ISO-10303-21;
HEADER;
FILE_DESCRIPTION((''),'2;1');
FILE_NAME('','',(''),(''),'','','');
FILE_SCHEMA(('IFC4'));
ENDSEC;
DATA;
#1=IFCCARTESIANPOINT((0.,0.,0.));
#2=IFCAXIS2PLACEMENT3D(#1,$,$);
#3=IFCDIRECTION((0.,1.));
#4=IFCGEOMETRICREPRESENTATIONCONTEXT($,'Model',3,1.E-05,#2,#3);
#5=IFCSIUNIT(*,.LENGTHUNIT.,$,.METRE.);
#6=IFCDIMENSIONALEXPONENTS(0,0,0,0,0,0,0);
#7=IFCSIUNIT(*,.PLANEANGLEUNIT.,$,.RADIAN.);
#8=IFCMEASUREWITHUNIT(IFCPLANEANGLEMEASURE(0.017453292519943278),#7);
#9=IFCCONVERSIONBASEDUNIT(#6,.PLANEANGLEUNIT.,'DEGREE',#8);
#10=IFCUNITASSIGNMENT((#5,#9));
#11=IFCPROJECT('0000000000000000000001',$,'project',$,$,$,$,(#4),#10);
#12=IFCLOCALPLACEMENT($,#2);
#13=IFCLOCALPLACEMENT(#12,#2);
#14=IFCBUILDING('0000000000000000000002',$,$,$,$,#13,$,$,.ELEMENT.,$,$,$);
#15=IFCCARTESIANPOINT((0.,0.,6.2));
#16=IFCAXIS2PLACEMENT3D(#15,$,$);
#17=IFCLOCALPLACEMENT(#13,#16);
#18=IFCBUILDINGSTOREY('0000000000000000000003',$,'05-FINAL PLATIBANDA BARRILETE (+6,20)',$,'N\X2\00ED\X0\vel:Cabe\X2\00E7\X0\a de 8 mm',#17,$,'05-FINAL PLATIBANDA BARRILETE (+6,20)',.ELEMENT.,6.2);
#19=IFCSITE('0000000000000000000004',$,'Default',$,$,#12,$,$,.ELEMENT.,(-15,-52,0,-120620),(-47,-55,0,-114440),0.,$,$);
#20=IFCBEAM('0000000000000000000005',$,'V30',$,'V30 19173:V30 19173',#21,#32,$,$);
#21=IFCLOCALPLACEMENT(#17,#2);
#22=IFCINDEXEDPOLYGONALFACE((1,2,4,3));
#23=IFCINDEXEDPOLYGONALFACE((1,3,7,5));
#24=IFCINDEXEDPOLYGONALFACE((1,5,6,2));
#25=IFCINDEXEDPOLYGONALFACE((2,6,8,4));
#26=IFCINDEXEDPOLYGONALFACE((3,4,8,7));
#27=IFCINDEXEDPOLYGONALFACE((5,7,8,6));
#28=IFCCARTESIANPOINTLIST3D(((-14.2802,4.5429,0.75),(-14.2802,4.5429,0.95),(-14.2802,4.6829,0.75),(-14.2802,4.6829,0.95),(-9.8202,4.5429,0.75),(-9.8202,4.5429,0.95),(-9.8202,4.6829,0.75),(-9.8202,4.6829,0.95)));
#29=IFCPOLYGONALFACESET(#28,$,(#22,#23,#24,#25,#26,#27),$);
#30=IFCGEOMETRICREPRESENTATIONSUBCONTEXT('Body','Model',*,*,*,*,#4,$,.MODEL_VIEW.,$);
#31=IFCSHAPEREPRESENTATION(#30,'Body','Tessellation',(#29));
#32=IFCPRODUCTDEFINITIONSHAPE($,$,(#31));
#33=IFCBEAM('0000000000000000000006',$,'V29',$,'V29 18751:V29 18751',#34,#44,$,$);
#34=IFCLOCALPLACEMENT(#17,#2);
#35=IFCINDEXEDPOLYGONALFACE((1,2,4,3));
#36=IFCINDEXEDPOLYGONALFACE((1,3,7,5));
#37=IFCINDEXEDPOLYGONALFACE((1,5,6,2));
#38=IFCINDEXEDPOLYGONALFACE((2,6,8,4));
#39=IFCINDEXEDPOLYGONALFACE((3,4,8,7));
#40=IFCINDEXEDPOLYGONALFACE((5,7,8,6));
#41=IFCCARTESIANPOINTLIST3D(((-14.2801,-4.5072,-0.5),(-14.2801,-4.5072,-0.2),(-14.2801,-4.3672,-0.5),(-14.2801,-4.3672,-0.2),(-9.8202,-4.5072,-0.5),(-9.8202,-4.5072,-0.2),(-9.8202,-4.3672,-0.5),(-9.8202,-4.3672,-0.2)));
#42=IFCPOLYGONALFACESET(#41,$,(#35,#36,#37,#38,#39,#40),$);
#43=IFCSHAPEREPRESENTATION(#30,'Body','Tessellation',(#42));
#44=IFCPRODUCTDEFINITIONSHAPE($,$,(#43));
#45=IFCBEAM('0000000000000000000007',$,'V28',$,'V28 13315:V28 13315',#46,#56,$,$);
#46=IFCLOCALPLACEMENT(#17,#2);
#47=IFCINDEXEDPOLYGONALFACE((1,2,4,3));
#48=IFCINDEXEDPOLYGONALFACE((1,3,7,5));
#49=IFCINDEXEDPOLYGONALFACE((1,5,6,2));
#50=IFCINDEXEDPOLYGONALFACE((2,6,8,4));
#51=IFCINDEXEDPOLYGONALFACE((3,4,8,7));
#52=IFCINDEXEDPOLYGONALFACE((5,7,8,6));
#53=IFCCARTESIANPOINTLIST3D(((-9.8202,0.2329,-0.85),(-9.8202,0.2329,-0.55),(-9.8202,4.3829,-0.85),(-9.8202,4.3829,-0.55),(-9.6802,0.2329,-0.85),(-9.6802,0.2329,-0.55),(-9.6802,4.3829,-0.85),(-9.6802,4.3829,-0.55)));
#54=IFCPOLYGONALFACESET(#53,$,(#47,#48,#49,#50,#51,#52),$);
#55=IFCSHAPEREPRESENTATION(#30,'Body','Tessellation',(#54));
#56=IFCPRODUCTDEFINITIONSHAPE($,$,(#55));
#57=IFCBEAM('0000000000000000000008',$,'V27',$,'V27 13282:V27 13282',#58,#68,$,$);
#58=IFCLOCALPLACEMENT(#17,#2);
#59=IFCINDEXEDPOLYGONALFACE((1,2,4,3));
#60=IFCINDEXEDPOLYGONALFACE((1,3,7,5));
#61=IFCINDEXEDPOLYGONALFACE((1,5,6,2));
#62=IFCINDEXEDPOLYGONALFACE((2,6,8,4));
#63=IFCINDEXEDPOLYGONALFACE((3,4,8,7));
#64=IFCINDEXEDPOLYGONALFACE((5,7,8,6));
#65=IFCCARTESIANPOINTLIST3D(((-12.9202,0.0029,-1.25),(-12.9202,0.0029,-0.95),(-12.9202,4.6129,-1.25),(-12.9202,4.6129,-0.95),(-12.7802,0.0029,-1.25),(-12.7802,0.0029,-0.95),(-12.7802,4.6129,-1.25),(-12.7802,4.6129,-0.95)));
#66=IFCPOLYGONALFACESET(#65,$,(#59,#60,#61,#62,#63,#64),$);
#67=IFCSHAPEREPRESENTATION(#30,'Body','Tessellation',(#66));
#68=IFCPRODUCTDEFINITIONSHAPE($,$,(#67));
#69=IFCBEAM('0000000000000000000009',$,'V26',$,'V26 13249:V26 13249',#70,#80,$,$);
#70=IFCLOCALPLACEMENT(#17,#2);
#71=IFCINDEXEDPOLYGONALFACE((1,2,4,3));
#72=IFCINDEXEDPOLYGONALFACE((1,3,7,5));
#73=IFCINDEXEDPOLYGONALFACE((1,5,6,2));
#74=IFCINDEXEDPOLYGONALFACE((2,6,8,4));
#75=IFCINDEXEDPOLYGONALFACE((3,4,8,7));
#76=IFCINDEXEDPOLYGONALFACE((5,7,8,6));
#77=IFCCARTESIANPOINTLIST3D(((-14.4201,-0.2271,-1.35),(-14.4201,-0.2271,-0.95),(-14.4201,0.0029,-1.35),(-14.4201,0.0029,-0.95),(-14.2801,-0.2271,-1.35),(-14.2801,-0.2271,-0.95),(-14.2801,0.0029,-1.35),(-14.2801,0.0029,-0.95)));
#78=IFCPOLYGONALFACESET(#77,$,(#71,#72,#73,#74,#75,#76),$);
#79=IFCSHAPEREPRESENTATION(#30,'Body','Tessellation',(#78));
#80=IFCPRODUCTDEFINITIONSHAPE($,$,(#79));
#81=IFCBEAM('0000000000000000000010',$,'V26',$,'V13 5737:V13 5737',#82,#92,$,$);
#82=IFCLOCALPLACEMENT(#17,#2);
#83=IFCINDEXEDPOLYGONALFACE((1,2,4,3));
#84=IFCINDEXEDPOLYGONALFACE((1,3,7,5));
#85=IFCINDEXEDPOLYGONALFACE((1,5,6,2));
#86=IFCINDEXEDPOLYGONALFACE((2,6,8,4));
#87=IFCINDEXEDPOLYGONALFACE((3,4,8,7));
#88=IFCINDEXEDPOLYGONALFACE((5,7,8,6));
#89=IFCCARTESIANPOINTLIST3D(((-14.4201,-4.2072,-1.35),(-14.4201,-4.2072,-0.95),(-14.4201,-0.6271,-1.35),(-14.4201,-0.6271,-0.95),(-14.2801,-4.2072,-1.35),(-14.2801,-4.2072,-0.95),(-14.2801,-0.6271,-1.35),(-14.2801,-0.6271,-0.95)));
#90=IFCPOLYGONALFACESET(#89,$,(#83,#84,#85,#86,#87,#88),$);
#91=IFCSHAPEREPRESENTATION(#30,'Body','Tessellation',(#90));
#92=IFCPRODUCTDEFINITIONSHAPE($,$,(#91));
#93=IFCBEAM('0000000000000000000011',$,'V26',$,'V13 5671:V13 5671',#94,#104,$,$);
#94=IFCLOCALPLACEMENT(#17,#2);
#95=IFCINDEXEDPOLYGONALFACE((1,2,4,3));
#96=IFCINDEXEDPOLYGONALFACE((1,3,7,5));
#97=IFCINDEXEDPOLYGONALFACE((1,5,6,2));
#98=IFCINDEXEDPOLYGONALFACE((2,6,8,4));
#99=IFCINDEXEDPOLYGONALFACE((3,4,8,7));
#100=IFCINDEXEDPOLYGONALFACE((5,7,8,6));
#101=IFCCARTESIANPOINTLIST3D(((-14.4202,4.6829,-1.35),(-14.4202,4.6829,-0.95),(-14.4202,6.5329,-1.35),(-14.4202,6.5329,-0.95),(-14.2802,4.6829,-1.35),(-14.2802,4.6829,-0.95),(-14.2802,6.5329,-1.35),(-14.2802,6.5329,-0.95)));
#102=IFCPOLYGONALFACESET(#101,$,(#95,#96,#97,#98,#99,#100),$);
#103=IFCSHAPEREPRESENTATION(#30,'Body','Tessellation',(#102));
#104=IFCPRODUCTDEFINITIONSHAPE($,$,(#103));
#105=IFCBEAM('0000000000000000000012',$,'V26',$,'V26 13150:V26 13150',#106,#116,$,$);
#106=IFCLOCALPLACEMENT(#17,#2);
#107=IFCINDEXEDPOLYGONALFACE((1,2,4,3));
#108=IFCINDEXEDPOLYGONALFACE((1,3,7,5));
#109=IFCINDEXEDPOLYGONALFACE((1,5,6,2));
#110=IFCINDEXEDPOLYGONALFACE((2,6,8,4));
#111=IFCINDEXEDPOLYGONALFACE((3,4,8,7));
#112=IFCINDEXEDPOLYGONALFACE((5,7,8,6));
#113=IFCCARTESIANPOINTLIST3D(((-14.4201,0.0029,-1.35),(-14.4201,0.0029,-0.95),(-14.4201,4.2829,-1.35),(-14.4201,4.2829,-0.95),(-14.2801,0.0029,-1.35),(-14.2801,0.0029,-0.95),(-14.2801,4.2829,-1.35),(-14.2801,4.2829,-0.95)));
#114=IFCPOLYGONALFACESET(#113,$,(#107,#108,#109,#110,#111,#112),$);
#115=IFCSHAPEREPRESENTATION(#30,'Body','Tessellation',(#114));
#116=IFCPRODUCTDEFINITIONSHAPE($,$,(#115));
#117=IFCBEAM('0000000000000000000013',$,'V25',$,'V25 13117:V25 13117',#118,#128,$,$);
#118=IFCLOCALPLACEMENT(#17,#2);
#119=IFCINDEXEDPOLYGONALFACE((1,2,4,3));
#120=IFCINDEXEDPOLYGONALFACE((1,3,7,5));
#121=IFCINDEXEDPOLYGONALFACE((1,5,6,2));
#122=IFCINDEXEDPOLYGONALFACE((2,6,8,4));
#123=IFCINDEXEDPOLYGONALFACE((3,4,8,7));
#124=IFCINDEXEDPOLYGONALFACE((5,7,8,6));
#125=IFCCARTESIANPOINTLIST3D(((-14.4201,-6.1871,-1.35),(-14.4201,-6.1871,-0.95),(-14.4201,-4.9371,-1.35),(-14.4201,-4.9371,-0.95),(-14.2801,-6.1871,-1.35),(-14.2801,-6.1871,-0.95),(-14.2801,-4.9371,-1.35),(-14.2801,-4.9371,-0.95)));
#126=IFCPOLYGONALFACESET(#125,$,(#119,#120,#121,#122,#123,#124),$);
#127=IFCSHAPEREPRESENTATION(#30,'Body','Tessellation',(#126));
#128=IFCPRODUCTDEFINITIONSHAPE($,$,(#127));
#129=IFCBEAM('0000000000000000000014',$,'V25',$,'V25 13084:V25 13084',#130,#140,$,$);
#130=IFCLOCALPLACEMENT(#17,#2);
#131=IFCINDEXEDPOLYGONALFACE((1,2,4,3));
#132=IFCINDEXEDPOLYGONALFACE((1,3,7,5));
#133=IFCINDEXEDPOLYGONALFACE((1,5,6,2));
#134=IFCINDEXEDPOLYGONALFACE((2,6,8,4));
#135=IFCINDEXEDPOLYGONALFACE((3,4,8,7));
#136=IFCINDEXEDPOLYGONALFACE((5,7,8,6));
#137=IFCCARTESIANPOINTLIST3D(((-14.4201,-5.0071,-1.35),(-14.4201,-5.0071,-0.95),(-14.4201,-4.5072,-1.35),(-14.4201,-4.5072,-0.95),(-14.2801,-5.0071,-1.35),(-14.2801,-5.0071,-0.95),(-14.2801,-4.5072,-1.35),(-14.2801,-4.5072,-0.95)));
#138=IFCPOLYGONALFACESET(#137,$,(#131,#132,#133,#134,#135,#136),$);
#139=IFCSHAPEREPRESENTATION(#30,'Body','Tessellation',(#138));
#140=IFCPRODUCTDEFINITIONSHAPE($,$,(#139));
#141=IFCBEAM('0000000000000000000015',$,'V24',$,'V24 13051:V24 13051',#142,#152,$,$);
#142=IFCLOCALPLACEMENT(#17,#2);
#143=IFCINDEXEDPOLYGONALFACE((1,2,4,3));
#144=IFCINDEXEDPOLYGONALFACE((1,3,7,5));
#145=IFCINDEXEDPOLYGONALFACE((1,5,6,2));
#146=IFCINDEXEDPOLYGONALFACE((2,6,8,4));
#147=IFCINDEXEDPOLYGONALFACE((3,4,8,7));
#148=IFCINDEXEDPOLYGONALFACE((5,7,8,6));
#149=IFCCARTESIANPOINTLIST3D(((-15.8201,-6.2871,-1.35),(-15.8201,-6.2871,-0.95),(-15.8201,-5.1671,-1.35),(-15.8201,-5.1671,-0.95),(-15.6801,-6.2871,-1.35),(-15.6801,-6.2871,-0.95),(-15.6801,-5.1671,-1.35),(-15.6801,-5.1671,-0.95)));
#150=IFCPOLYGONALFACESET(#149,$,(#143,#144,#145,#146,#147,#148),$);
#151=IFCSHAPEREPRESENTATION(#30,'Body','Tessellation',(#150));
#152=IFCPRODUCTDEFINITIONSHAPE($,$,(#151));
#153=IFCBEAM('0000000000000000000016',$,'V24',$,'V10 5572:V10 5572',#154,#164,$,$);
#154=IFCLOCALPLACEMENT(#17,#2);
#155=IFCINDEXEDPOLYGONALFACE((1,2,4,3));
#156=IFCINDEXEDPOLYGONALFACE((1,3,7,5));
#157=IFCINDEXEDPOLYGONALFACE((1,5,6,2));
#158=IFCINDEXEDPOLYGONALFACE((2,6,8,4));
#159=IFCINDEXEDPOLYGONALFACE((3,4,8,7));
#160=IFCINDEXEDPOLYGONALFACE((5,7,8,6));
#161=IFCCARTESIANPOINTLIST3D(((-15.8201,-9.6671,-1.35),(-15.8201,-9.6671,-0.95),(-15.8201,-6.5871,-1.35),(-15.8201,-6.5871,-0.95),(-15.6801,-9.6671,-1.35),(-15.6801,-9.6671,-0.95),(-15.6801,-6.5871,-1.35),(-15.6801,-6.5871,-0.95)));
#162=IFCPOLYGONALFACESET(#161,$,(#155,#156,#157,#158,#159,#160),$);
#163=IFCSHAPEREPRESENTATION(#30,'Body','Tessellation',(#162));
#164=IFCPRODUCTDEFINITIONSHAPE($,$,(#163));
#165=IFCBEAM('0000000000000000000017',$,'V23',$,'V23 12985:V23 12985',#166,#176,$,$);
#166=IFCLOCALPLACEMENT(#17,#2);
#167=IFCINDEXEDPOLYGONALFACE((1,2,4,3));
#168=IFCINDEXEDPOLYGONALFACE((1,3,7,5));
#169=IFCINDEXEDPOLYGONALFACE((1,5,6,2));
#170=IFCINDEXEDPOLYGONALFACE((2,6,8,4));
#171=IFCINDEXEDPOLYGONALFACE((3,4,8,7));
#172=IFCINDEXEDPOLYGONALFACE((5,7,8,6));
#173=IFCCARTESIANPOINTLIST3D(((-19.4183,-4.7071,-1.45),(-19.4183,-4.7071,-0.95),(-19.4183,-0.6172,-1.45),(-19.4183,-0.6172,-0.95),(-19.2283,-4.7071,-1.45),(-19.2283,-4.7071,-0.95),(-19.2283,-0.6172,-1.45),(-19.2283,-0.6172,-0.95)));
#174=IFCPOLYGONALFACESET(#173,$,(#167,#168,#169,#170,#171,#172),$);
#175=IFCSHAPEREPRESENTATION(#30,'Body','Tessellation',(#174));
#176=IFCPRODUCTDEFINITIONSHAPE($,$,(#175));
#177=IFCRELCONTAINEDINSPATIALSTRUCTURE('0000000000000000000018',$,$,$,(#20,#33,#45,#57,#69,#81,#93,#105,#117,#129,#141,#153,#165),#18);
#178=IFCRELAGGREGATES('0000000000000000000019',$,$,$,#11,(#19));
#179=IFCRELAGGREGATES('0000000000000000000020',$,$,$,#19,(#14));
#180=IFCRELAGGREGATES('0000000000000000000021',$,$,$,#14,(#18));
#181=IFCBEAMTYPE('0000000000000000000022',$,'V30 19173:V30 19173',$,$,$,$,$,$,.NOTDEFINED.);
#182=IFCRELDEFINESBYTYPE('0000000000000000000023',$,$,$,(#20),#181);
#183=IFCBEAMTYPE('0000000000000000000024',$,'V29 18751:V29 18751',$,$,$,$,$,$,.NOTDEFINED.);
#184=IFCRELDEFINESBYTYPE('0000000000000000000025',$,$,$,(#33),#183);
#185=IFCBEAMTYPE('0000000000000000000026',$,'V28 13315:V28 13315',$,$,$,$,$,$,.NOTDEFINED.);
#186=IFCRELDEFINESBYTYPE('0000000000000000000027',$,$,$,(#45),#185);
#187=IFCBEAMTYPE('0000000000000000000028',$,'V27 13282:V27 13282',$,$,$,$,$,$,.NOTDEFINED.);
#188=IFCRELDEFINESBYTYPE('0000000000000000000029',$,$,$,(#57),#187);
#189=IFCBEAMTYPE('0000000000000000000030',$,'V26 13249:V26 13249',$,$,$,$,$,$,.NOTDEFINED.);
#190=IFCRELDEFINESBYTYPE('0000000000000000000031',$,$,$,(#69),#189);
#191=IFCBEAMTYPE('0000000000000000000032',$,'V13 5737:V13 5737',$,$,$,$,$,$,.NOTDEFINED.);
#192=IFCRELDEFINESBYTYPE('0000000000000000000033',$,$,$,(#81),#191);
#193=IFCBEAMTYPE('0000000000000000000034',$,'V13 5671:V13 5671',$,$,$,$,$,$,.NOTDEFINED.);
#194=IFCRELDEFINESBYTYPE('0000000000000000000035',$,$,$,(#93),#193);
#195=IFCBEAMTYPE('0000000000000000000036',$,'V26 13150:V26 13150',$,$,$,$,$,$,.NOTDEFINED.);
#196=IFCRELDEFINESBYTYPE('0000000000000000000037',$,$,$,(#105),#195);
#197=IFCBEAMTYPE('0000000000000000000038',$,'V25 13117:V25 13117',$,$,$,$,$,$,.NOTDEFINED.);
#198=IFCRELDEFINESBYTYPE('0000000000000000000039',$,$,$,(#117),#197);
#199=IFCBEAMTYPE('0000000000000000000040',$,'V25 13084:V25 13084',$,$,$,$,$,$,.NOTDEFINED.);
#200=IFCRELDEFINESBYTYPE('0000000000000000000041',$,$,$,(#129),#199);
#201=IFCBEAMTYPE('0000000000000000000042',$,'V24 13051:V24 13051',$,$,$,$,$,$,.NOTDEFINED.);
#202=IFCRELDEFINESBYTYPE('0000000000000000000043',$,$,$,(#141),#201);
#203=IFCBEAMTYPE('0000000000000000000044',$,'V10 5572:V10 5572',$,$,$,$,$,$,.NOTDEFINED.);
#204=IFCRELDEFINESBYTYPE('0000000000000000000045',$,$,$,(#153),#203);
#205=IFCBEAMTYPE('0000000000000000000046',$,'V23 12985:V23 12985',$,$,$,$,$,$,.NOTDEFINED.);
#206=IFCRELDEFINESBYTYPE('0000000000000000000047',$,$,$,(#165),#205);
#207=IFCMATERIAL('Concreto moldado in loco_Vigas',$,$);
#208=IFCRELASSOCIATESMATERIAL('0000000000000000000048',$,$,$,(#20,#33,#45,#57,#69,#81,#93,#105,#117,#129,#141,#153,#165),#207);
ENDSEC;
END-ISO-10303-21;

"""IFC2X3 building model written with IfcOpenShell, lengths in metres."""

from ifc_helpers import new_model, entity, si_unit, converted_unit, direction, frame, frame_2d, origin, place, context, subcontext, project, spatial, rectangle, extrude, material, type_object, element, save


model = new_model("IFC2X3")

# Units and contexts
model_context = context("Model", 3, precision=1e-05, world=origin(), true_north=direction((0.0, 1.0)))
body_context = subcontext(model_context, "Body", "Model", "MODEL_VIEW")
ifc_project = project(units=[si_unit("LENGTHUNIT", "METRE"), converted_unit("PLANEANGLEUNIT", "DEGREE", entity("IfcPlaneAngleMeasure", 0.017453292519943278), si_unit("PLANEANGLEUNIT", "RADIAN"), dimensions=[0, 0, 0, 0, 0, 0, 0])], contexts=[model_context])

# Site, building, storey
site_placement = place(None, origin())
site = spatial("IfcSite", under=ifc_project, at=site_placement, Name="Default", CompositionType="ELEMENT", RefLatitude=(-15, -52, 0, -120620), RefLongitude=(-47, -55, 0, -114440), RefElevation=0.0)
building_placement = place(site_placement, origin())
building = spatial("IfcBuilding", under=site, at=building_placement, CompositionType="ELEMENT")
storey_placement = place(building_placement, frame((0.0, 0.0, 6.2)))
storey = spatial("IfcBuildingStorey", under=building, at=storey_placement, Name="05-FINAL PLATIBANDA BARRILETE (+6,20)", ObjectType="Nível:Cabeça de 8 mm", LongName="05-FINAL PLATIBANDA BARRILETE (+6,20)", CompositionType="ELEMENT", Elevation=6.2)

# Beams
ifc_material_1 = material(Name="Concreto moldado in loco_Vigas")
beam_type_1 = type_object("IfcBeamType", Name="V30 19173:V30 19173", PredefinedType="NOTDEFINED")
beam_1_placement = place(storey_placement, origin())
element("IfcBeam", 1, at=beam_1_placement, inside=storey, type_object=beam_type_1, material=ifc_material_1, Name="V30", ObjectType="V30 19173:V30 19173", context=body_context, shape_type="SweptSolid", body=[
    extrude(rectangle(XDim=0.2, YDim=0.14, at=frame_2d((0.0, 0.0), x_axis=(1.0, 0.0))), frame((-14.2802, 4.6129, 0.85), z_axis=(1.0, 0.0, 0.0), x_axis=(0.0, 0.0, -1.0)), (0.0, 0.0, 1.0), 4.46),
])
beam_type_2 = type_object("IfcBeamType", Name="V29 18751:V29 18751", PredefinedType="NOTDEFINED")
beam_2_placement = place(storey_placement, origin())
element("IfcBeam", 2, at=beam_2_placement, inside=storey, type_object=beam_type_2, material=ifc_material_1, Name="V29", ObjectType="V29 18751:V29 18751", context=body_context, shape_type="SweptSolid", body=[
    extrude(rectangle(XDim=0.3, YDim=0.14, at=frame_2d((0.0, 0.0), x_axis=(1.0, 0.0))), frame((-14.2801, -4.4372, -0.35), z_axis=(1.0, 0.0, 0.0), x_axis=(0.0, 0.0, -1.0)), (0.0, 0.0, 1.0), 4.4599),
])
beam_type_3 = type_object("IfcBeamType", Name="V28 13315:V28 13315", PredefinedType="NOTDEFINED")
beam_3_placement = place(storey_placement, origin())
element("IfcBeam", 3, at=beam_3_placement, inside=storey, type_object=beam_type_3, material=ifc_material_1, Name="V28", ObjectType="V28 13315:V28 13315", context=body_context, shape_type="SweptSolid", body=[
    extrude(rectangle(XDim=0.3, YDim=4.15, at=frame_2d((0.0, 0.0), x_axis=(0.0, 1.0))), frame((-9.8202, 2.3079, -0.7), z_axis=(1.0, 0.0, 0.0), x_axis=(0.0, -1.0, 0.0)), (0.0, 0.0, 1.0), 0.14),
])
beam_type_4 = type_object("IfcBeamType", Name="V27 13282:V27 13282", PredefinedType="NOTDEFINED")
beam_4_placement = place(storey_placement, origin())
element("IfcBeam", 4, at=beam_4_placement, inside=storey, type_object=beam_type_4, material=ifc_material_1, Name="V27", ObjectType="V27 13282:V27 13282", context=body_context, shape_type="SweptSolid", body=[
    extrude(rectangle(XDim=0.3, YDim=4.61, at=frame_2d((0.0, 0.0), x_axis=(0.0, 1.0))), frame((-12.9202, 2.3079, -1.1), z_axis=(1.0, 0.0, 0.0), x_axis=(0.0, -1.0, 0.0)), (0.0, 0.0, 1.0), 0.14),
])
beam_type_5 = type_object("IfcBeamType", Name="V26 13249:V26 13249", PredefinedType="NOTDEFINED")
beam_5_placement = place(storey_placement, origin())
element("IfcBeam", 5, at=beam_5_placement, inside=storey, type_object=beam_type_5, material=ifc_material_1, Name="V26", ObjectType="V26 13249:V26 13249", context=body_context, shape_type="SweptSolid", body=[
    extrude(rectangle(XDim=0.4, YDim=0.23, at=frame_2d((0.0, 0.0), x_axis=(0.0, 1.0))), frame((-14.4201, -0.1121, -1.15), z_axis=(1.0, 0.0, 0.0), x_axis=(0.0, -1.0, 0.0)), (0.0, 0.0, 1.0), 0.14),
])
beam_type_6 = type_object("IfcBeamType", Name="V13 5737:V13 5737", PredefinedType="NOTDEFINED")
beam_6_placement = place(storey_placement, origin())
element("IfcBeam", 6, at=beam_6_placement, inside=storey, type_object=beam_type_6, material=ifc_material_1, Name="V26", ObjectType="V13 5737:V13 5737", context=body_context, shape_type="SweptSolid", body=[
    extrude(rectangle(XDim=0.4, YDim=3.5801, at=frame_2d((0.0, 0.0), x_axis=(0.0, 1.0))), frame((-14.4201, -2.4171, -1.15), z_axis=(1.0, 0.0, 0.0), x_axis=(0.0, -1.0, 0.0)), (0.0, 0.0, 1.0), 0.14),
])
beam_type_7 = type_object("IfcBeamType", Name="V13 5671:V13 5671", PredefinedType="NOTDEFINED")
beam_7_placement = place(storey_placement, origin())
element("IfcBeam", 7, at=beam_7_placement, inside=storey, type_object=beam_type_7, material=ifc_material_1, Name="V26", ObjectType="V13 5671:V13 5671", context=body_context, shape_type="SweptSolid", body=[
    extrude(rectangle(XDim=0.4, YDim=1.85, at=frame_2d((0.0, 0.0), x_axis=(0.0, 1.0))), frame((-14.4202, 5.6079, -1.15), z_axis=(1.0, 0.0, 0.0), x_axis=(0.0, -1.0, 0.0)), (0.0, 0.0, 1.0), 0.14),
])
beam_type_8 = type_object("IfcBeamType", Name="V26 13150:V26 13150", PredefinedType="NOTDEFINED")
beam_8_placement = place(storey_placement, origin())
element("IfcBeam", 8, at=beam_8_placement, inside=storey, type_object=beam_type_8, material=ifc_material_1, Name="V26", ObjectType="V26 13150:V26 13150", context=body_context, shape_type="SweptSolid", body=[
    extrude(rectangle(XDim=0.4, YDim=4.28, at=frame_2d((0.0, 0.0), x_axis=(0.0, 1.0))), frame((-14.4201, 2.1429, -1.15), z_axis=(1.0, 0.0, 0.0), x_axis=(0.0, -1.0, 0.0)), (0.0, 0.0, 1.0), 0.14),
])
beam_type_9 = type_object("IfcBeamType", Name="V25 13117:V25 13117", PredefinedType="NOTDEFINED")
beam_9_placement = place(storey_placement, origin())
element("IfcBeam", 9, at=beam_9_placement, inside=storey, type_object=beam_type_9, material=ifc_material_1, Name="V25", ObjectType="V25 13117:V25 13117", context=body_context, shape_type="SweptSolid", body=[
    extrude(rectangle(XDim=0.4, YDim=1.25, at=frame_2d((0.0, 0.0), x_axis=(0.0, 1.0))), frame((-14.4201, -5.5621, -1.15), z_axis=(1.0, 0.0, 0.0), x_axis=(0.0, -1.0, 0.0)), (0.0, 0.0, 1.0), 0.14),
])
beam_type_10 = type_object("IfcBeamType", Name="V25 13084:V25 13084", PredefinedType="NOTDEFINED")
beam_10_placement = place(storey_placement, origin())
element("IfcBeam", 10, at=beam_10_placement, inside=storey, type_object=beam_type_10, material=ifc_material_1, Name="V25", ObjectType="V25 13084:V25 13084", context=body_context, shape_type="SweptSolid", body=[
    extrude(rectangle(XDim=0.4, YDim=0.4999, at=frame_2d((0.0, 0.0), x_axis=(0.0, 1.0))), frame((-14.4201, -4.7571, -1.15), z_axis=(1.0, 0.0, 0.0), x_axis=(0.0, -1.0, 0.0)), (0.0, 0.0, 1.0), 0.14),
])
beam_type_11 = type_object("IfcBeamType", Name="V24 13051:V24 13051", PredefinedType="NOTDEFINED")
beam_11_placement = place(storey_placement, origin())
element("IfcBeam", 11, at=beam_11_placement, inside=storey, type_object=beam_type_11, material=ifc_material_1, Name="V24", ObjectType="V24 13051:V24 13051", context=body_context, shape_type="SweptSolid", body=[
    extrude(rectangle(XDim=0.4, YDim=1.12, at=frame_2d((0.0, 0.0), x_axis=(0.0, 1.0))), frame((-15.8201, -5.7271, -1.15), z_axis=(1.0, 0.0, 0.0), x_axis=(0.0, -1.0, 0.0)), (0.0, 0.0, 1.0), 0.14),
])
beam_type_12 = type_object("IfcBeamType", Name="V10 5572:V10 5572", PredefinedType="NOTDEFINED")
beam_12_placement = place(storey_placement, origin())
element("IfcBeam", 12, at=beam_12_placement, inside=storey, type_object=beam_type_12, material=ifc_material_1, Name="V24", ObjectType="V10 5572:V10 5572", context=body_context, shape_type="SweptSolid", body=[
    extrude(rectangle(XDim=0.4, YDim=3.08, at=frame_2d((0.0, 0.0), x_axis=(0.0, 1.0))), frame((-15.8201, -8.1271, -1.15), z_axis=(1.0, 0.0, 0.0), x_axis=(0.0, -1.0, 0.0)), (0.0, 0.0, 1.0), 0.14),
])
beam_type_13 = type_object("IfcBeamType", Name="V23 12985:V23 12985", PredefinedType="NOTDEFINED")
beam_13_placement = place(storey_placement, origin())
element("IfcBeam", 13, at=beam_13_placement, inside=storey, type_object=beam_type_13, material=ifc_material_1, Name="V23", ObjectType="V23 12985:V23 12985", context=body_context, shape_type="SweptSolid", body=[
    extrude(rectangle(XDim=0.5, YDim=4.0899, at=frame_2d((0.0, 0.0), x_axis=(0.0, 1.0))), frame((-19.4183, -2.6621, -1.2), z_axis=(1.0, 0.0, 0.0), x_axis=(0.0, -1.0, 0.0)), (0.0, 0.0, 1.0), 0.19),
])

save(model, "model.ifc")
